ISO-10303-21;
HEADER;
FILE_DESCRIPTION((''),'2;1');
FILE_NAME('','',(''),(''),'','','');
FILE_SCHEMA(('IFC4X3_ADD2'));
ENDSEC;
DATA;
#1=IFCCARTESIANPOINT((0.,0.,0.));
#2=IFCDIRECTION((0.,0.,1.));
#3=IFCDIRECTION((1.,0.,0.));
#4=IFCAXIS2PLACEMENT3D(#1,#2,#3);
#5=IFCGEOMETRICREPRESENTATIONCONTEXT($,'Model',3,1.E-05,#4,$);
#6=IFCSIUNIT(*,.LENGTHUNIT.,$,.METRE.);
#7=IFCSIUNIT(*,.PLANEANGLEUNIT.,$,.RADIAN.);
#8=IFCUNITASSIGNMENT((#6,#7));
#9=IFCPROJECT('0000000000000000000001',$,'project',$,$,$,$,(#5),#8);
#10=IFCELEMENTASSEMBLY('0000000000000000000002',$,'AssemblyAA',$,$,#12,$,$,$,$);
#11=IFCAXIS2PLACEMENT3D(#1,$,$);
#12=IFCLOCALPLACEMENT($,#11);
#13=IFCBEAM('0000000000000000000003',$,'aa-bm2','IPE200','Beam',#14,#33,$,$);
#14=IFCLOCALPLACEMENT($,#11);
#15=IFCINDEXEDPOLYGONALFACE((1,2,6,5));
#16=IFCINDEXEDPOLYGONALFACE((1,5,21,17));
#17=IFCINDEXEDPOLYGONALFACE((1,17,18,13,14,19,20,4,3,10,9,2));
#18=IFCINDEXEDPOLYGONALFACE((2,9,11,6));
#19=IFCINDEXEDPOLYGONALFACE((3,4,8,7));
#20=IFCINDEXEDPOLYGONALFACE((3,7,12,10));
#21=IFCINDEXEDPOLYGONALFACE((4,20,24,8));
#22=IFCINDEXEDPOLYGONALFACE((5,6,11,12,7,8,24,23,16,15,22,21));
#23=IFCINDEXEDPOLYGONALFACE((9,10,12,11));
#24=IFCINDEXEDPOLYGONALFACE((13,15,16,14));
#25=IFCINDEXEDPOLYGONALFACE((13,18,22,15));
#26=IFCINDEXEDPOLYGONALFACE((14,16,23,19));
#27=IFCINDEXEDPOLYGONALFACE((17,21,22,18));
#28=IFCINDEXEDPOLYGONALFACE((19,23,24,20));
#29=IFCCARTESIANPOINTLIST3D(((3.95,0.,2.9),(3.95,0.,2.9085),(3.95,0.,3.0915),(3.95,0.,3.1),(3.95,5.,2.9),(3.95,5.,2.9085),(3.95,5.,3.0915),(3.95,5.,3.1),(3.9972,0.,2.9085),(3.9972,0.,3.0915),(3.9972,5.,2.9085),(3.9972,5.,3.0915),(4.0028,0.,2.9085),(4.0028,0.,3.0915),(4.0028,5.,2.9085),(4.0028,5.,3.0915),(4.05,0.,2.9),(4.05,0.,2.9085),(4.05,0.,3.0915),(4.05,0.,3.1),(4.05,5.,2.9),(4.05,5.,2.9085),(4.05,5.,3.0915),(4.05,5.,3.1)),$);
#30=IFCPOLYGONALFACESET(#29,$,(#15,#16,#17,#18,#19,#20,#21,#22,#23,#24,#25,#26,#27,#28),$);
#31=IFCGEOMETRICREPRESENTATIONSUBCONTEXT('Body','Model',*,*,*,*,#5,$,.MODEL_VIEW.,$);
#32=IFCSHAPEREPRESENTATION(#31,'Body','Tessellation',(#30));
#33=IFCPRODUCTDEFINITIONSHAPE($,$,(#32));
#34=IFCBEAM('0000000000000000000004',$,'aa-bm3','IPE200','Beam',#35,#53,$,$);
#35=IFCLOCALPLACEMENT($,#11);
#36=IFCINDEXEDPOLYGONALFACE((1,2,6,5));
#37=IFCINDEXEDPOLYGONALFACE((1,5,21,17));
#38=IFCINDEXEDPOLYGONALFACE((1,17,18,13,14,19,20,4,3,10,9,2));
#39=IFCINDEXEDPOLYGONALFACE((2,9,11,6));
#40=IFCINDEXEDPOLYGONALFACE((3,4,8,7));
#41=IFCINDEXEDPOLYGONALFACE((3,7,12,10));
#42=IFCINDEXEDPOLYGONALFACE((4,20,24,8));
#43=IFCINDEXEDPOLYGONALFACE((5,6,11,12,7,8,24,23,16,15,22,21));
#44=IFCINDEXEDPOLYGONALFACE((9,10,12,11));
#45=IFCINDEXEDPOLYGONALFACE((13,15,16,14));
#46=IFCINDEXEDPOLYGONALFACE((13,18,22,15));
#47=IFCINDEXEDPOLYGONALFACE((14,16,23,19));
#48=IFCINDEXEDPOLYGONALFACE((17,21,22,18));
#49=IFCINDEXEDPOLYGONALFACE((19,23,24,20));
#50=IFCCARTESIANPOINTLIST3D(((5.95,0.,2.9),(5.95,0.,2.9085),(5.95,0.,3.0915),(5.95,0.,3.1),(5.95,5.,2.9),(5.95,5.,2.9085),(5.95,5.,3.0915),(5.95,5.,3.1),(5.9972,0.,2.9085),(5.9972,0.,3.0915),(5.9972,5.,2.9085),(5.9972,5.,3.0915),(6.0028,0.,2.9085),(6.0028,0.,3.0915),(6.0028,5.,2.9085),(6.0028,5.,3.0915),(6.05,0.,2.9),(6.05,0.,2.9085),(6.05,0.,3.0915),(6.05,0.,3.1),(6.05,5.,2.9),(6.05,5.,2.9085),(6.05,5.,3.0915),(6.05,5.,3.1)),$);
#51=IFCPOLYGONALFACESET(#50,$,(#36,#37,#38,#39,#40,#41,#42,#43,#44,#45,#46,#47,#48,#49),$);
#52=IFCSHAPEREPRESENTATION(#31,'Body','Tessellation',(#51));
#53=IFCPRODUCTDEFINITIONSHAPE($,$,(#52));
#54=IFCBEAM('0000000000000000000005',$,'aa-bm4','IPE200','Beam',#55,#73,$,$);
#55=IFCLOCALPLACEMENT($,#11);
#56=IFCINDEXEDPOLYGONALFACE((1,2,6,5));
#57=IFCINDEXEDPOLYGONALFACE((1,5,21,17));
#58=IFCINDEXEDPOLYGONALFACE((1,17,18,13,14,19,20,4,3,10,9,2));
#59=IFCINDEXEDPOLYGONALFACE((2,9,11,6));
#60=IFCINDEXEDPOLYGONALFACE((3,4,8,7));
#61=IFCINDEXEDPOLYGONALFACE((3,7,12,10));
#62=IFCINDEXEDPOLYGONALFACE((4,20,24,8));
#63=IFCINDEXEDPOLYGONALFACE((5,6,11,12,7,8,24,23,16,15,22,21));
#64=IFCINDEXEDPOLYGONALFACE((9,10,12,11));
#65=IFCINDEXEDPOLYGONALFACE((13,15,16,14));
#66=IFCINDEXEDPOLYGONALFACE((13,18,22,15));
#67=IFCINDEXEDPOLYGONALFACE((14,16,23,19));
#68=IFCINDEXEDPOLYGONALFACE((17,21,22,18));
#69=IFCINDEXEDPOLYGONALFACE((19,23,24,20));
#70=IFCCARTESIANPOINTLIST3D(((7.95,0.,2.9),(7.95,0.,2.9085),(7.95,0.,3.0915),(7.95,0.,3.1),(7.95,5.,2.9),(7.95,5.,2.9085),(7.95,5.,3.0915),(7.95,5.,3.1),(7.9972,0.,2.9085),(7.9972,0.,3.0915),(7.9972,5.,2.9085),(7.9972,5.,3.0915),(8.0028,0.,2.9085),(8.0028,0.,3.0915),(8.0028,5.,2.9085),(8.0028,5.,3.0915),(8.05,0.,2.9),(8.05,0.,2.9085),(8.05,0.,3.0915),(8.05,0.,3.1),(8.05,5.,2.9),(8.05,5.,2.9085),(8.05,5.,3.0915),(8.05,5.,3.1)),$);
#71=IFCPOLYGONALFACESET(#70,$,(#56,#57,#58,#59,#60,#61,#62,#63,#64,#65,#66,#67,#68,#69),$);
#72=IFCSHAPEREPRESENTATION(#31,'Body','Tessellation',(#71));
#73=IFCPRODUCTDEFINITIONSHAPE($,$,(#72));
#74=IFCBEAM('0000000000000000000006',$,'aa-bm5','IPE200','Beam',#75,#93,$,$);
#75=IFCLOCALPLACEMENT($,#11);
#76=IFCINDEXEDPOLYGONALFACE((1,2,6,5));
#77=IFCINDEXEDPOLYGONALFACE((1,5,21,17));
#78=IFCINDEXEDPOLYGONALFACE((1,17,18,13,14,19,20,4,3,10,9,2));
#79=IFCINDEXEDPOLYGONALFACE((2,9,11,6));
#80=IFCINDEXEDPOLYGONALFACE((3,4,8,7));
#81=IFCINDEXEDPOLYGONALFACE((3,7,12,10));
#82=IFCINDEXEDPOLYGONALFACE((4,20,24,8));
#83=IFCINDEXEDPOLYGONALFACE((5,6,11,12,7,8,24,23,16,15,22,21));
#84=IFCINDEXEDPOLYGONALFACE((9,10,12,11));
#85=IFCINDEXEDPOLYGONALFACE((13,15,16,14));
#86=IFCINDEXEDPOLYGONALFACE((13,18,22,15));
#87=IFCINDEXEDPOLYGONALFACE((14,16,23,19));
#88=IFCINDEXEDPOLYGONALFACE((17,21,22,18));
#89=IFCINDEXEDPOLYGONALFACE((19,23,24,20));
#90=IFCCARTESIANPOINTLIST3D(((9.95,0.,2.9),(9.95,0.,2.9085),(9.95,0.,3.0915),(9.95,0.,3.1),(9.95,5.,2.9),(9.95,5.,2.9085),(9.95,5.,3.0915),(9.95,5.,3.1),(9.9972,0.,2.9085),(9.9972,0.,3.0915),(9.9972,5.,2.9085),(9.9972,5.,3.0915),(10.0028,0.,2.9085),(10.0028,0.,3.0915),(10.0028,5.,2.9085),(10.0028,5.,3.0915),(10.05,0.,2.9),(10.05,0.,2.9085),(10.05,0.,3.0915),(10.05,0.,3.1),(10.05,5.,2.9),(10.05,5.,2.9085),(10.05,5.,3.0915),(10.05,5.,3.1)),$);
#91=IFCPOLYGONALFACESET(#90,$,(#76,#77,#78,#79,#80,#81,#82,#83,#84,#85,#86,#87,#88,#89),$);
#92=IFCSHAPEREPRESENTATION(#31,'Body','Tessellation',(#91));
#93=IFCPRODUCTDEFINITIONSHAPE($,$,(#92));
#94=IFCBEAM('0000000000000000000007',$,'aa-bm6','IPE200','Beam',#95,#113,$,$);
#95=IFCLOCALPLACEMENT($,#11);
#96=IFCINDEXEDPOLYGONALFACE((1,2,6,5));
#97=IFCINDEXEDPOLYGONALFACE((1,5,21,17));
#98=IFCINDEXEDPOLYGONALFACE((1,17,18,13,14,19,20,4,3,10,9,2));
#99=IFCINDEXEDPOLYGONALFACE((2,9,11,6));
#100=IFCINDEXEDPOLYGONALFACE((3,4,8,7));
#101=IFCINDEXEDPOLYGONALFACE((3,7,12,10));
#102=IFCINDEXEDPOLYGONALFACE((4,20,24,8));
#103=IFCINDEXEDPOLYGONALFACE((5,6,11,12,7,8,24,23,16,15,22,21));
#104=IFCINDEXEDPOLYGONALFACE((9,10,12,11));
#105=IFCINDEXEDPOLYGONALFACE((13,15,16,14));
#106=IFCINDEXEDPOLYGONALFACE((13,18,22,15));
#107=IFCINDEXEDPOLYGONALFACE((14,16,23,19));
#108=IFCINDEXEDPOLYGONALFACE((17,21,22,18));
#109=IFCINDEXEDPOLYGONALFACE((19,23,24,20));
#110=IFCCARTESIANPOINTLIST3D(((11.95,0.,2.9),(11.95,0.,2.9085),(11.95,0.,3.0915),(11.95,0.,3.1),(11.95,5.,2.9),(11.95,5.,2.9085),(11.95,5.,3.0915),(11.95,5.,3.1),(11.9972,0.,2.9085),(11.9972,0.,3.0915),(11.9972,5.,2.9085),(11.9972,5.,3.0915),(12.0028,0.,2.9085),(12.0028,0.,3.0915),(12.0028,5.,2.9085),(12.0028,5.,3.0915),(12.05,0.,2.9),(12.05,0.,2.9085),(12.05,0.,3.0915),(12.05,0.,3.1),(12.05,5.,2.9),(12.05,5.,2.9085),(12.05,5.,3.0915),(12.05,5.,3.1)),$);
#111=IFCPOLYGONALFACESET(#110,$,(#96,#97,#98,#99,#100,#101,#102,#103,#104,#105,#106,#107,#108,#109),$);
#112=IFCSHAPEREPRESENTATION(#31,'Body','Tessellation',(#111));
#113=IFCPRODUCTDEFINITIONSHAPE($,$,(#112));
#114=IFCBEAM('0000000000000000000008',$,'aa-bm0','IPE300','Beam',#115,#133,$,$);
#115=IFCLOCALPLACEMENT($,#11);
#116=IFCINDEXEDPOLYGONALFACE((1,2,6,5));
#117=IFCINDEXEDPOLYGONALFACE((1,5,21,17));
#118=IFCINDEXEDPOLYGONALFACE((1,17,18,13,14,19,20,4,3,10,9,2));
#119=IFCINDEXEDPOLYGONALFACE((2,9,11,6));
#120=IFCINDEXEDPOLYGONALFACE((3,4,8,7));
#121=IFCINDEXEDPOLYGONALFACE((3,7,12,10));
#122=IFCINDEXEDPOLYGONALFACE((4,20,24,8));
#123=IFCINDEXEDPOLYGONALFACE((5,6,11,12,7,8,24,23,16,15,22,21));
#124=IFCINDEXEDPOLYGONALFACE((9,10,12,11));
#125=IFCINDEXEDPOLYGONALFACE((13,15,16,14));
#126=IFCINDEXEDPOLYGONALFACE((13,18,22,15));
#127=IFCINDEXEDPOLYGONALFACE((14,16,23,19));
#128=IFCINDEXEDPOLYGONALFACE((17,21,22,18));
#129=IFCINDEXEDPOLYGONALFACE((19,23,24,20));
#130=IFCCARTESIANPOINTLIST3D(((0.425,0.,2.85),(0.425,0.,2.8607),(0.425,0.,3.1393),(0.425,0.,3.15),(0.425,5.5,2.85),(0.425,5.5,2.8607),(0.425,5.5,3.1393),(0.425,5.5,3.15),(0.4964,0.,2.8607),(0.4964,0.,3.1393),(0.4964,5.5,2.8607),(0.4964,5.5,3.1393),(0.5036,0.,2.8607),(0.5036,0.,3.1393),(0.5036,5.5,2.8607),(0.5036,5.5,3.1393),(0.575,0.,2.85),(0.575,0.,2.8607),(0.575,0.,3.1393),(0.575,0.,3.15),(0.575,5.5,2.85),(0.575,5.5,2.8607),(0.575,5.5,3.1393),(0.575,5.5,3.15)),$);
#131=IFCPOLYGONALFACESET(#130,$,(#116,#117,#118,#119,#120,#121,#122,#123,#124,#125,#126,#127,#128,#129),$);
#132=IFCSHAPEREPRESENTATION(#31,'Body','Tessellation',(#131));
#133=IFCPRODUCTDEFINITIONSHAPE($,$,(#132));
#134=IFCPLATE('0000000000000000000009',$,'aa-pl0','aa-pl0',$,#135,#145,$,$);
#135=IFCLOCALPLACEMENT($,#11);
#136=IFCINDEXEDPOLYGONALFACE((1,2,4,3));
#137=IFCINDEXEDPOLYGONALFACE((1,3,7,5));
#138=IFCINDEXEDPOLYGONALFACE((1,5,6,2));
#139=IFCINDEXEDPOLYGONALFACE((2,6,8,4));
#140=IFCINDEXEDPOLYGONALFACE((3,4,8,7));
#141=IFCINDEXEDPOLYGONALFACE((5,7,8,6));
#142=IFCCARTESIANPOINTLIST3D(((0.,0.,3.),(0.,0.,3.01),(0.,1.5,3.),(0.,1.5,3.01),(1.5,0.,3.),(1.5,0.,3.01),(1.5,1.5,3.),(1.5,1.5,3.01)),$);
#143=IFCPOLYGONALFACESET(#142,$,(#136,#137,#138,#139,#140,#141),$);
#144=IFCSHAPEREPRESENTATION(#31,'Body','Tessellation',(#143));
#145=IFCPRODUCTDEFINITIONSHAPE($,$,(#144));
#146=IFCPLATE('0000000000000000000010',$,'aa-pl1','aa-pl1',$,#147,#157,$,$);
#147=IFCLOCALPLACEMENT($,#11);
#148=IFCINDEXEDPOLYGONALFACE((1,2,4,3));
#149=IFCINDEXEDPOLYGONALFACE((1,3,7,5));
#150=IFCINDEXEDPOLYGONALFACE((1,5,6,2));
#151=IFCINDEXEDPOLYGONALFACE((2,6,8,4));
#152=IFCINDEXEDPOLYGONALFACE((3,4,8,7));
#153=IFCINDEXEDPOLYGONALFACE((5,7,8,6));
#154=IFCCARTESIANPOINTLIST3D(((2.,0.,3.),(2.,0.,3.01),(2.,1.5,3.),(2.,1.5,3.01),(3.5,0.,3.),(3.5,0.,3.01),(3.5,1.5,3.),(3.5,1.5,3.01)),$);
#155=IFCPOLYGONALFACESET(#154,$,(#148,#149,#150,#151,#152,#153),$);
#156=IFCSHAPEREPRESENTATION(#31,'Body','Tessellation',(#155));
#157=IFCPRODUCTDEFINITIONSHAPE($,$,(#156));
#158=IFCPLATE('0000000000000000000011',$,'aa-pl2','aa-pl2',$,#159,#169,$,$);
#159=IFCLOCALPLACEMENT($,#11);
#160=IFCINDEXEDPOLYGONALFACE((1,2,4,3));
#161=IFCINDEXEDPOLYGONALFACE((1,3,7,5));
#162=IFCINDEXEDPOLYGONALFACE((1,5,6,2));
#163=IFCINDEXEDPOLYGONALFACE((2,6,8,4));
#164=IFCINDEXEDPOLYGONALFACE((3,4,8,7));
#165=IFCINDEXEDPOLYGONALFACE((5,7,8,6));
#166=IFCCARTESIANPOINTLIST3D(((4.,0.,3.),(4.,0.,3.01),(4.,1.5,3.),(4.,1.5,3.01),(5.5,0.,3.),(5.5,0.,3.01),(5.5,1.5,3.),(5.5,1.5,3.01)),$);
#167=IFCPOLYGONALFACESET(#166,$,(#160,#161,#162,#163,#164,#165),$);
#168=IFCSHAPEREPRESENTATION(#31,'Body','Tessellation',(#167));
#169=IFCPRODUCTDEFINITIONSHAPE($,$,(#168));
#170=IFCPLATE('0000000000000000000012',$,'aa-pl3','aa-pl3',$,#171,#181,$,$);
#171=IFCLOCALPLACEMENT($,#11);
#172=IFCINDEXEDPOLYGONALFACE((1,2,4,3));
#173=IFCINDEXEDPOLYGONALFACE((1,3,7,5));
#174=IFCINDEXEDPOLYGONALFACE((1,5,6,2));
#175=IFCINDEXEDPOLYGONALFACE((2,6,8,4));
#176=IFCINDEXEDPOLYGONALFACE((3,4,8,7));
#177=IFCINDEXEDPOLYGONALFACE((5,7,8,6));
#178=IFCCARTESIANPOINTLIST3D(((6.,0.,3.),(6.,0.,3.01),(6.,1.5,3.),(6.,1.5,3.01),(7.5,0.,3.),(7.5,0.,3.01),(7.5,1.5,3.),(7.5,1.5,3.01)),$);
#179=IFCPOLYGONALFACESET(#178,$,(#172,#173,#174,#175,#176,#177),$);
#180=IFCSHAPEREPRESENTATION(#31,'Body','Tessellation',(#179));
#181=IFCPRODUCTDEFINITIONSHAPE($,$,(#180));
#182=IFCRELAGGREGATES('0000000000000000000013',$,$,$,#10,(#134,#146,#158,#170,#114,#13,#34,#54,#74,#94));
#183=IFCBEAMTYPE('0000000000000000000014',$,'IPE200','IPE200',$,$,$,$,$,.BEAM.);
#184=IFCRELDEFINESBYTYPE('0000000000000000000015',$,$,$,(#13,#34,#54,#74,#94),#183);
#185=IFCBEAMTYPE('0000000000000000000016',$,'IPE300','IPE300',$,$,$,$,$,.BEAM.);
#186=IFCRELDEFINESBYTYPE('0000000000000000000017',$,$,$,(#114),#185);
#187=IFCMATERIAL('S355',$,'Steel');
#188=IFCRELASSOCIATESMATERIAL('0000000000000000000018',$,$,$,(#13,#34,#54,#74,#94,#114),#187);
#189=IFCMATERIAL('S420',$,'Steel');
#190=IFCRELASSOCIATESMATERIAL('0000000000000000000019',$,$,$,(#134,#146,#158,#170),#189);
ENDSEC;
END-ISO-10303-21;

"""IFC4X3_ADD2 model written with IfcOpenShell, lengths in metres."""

from ifc_helpers import new_model, si_unit, frame, origin_with_axes, place, context, subcontext, project, line, indexed_curve, i_section, outline, extrude, material, material_profile, profile_set, profile_usage, type_object, element, aggregate, save


model = new_model("IFC4X3_ADD2")

# Units and contexts
model_context = context("Model", 3, precision=1e-05, world=origin_with_axes())
body_context = subcontext(model_context, "Body", "Model", "MODEL_VIEW")
ifc_project = project(units=[si_unit("LENGTHUNIT", "METRE"), si_unit("PLANEANGLEUNIT", "RADIAN")], contexts=[model_context])

# Element assembly, beams, plates
placement_1 = place(None, origin_with_axes())
placement_2 = place(placement_1, origin_with_axes())
assembly_placement = place(placement_2, origin_with_axes())
assembly = element("IfcElementAssembly", 1, at=assembly_placement, Name="AssemblyAA")
ifc_material_1 = material(Name="S355", Category="Steel")
ifc_material_profile_1 = material_profile(ifc_material_1, i_section(OverallWidth=0.1, OverallDepth=0.2, WebThickness=0.0056, FlangeThickness=0.0085), Name="IPE200", Category="LoadBearing")
ifc_profile_set_1 = profile_set([ifc_material_profile_1], Name="IPE200")
ifc_profile_usage_1 = profile_usage(ifc_profile_set_1, cardinal=5)
beam_type_1 = type_object("IfcBeamType", Name="IPE200", Description="IPE200", PredefinedType="BEAM")
placement_3 = place(assembly_placement, origin_with_axes())
beam_1_placement = place(placement_3, origin_with_axes())
beam_1 = element("IfcBeam", 2, at=beam_1_placement, type_object=beam_type_1, material=ifc_profile_usage_1, Name="aa-bm2", Description="IPE200", ObjectType="Beam", context=body_context, shape_type="SolidModel", body=[
    extrude(i_section(OverallWidth=0.1, OverallDepth=0.2, WebThickness=0.0056, FlangeThickness=0.0085), frame((4.0, 0.0, 3.0), z_axis=(0.0, 1.0, 0.0), x_axis=(-1.0, 0.0, 0.0)), (0.0, 0.0, 1.0), 5.0),
])
ifc_material_profile_2 = material_profile(ifc_material_1, i_section(OverallWidth=0.1, OverallDepth=0.2, WebThickness=0.0056, FlangeThickness=0.0085), Name="IPE200", Category="LoadBearing")
ifc_profile_set_2 = profile_set([ifc_material_profile_2], Name="IPE200")
ifc_profile_usage_2 = profile_usage(ifc_profile_set_2, cardinal=5)
placement_4 = place(assembly_placement, origin_with_axes())
beam_2_placement = place(placement_4, origin_with_axes())
beam_2 = element("IfcBeam", 3, at=beam_2_placement, type_object=beam_type_1, material=ifc_profile_usage_2, Name="aa-bm3", Description="IPE200", ObjectType="Beam", context=body_context, shape_type="SolidModel", body=[
    extrude(i_section(OverallWidth=0.1, OverallDepth=0.2, WebThickness=0.0056, FlangeThickness=0.0085), frame((6.0, 0.0, 3.0), z_axis=(0.0, 1.0, 0.0), x_axis=(-1.0, 0.0, 0.0)), (0.0, 0.0, 1.0), 5.0),
])
ifc_material_profile_3 = material_profile(ifc_material_1, i_section(OverallWidth=0.1, OverallDepth=0.2, WebThickness=0.0056, FlangeThickness=0.0085), Name="IPE200", Category="LoadBearing")
ifc_profile_set_3 = profile_set([ifc_material_profile_3], Name="IPE200")
ifc_profile_usage_3 = profile_usage(ifc_profile_set_3, cardinal=5)
placement_5 = place(assembly_placement, origin_with_axes())
beam_3_placement = place(placement_5, origin_with_axes())
beam_3 = element("IfcBeam", 4, at=beam_3_placement, type_object=beam_type_1, material=ifc_profile_usage_3, Name="aa-bm4", Description="IPE200", ObjectType="Beam", context=body_context, shape_type="SolidModel", body=[
    extrude(i_section(OverallWidth=0.1, OverallDepth=0.2, WebThickness=0.0056, FlangeThickness=0.0085), frame((8.0, 0.0, 3.0), z_axis=(0.0, 1.0, 0.0), x_axis=(-1.0, 0.0, 0.0)), (0.0, 0.0, 1.0), 5.0),
])
ifc_material_profile_4 = material_profile(ifc_material_1, i_section(OverallWidth=0.1, OverallDepth=0.2, WebThickness=0.0056, FlangeThickness=0.0085), Name="IPE200", Category="LoadBearing")
ifc_profile_set_4 = profile_set([ifc_material_profile_4], Name="IPE200")
ifc_profile_usage_4 = profile_usage(ifc_profile_set_4, cardinal=5)
placement_6 = place(assembly_placement, origin_with_axes())
beam_4_placement = place(placement_6, origin_with_axes())
beam_4 = element("IfcBeam", 5, at=beam_4_placement, type_object=beam_type_1, material=ifc_profile_usage_4, Name="aa-bm5", Description="IPE200", ObjectType="Beam", context=body_context, shape_type="SolidModel", body=[
    extrude(i_section(OverallWidth=0.1, OverallDepth=0.2, WebThickness=0.0056, FlangeThickness=0.0085), frame((10.0, 0.0, 3.0), z_axis=(0.0, 1.0, 0.0), x_axis=(-1.0, 0.0, 0.0)), (0.0, 0.0, 1.0), 5.0),
])
ifc_material_profile_5 = material_profile(ifc_material_1, i_section(OverallWidth=0.1, OverallDepth=0.2, WebThickness=0.0056, FlangeThickness=0.0085), Name="IPE200", Category="LoadBearing")
ifc_profile_set_5 = profile_set([ifc_material_profile_5], Name="IPE200")
ifc_profile_usage_5 = profile_usage(ifc_profile_set_5, cardinal=5)
placement_7 = place(assembly_placement, origin_with_axes())
beam_5_placement = place(placement_7, origin_with_axes())
beam_5 = element("IfcBeam", 6, at=beam_5_placement, type_object=beam_type_1, material=ifc_profile_usage_5, Name="aa-bm6", Description="IPE200", ObjectType="Beam", context=body_context, shape_type="SolidModel", body=[
    extrude(i_section(OverallWidth=0.1, OverallDepth=0.2, WebThickness=0.0056, FlangeThickness=0.0085), frame((12.0, 0.0, 3.0), z_axis=(0.0, 1.0, 0.0), x_axis=(-1.0, 0.0, 0.0)), (0.0, 0.0, 1.0), 5.0),
])
ifc_material_profile_6 = material_profile(ifc_material_1, i_section(OverallWidth=0.15, OverallDepth=0.3, WebThickness=0.0071, FlangeThickness=0.0107), Name="IPE300", Category="LoadBearing")
ifc_profile_set_6 = profile_set([ifc_material_profile_6], Name="IPE300")
ifc_profile_usage_6 = profile_usage(ifc_profile_set_6, cardinal=5)
beam_type_2 = type_object("IfcBeamType", Name="IPE300", Description="IPE300", PredefinedType="BEAM")
placement_8 = place(assembly_placement, origin_with_axes())
beam_6_placement = place(placement_8, origin_with_axes())
beam_6 = element("IfcBeam", 7, at=beam_6_placement, type_object=beam_type_2, material=ifc_profile_usage_6, Name="aa-bm0", Description="IPE300", ObjectType="Beam", context=body_context, shape_type="SolidModel", body=[
    extrude(i_section(OverallWidth=0.15, OverallDepth=0.3, WebThickness=0.0071, FlangeThickness=0.0107), frame((0.5, 0.0, 3.0), z_axis=(0.0, 1.0, 0.0), x_axis=(-1.0, 0.0, 0.0)), (0.0, 0.0, 1.0), 5.5),
])
ifc_material_2 = material(Name="S420", Category="Steel")
plate_1_placement = place(None, origin_with_axes())
plate_1 = element("IfcPlate", 8, at=plate_1_placement, material=ifc_material_2, Name="aa-pl0", Description="aa-pl0", context=body_context, shape_type="SolidModel", body=[
    extrude(outline(indexed_curve([(0.0, 0.0), (0.0, 1.5), (1.5, 0.0), (1.5, 1.5)], segments=[line(3, 1), line(1, 2), line(2, 4), line(4, 3)])), frame((0.0, 0.0, 3.0), z_axis=(0.0, 0.0, 1.0), x_axis=(1.0, 0.0, 0.0)), (0.0, 0.0, 1.0), 0.01),
])
plate_2_placement = place(None, origin_with_axes())
plate_2 = element("IfcPlate", 9, at=plate_2_placement, material=ifc_material_2, Name="aa-pl1", Description="aa-pl1", context=body_context, shape_type="SolidModel", body=[
    extrude(outline(indexed_curve([(2.0, 0.0), (2.0, 1.5), (3.5, 0.0), (3.5, 1.5)], segments=[line(3, 1), line(1, 2), line(2, 4), line(4, 3)])), frame((0.0, 0.0, 3.0), z_axis=(0.0, 0.0, 1.0), x_axis=(1.0, 0.0, 0.0)), (0.0, 0.0, 1.0), 0.01),
])
plate_3_placement = place(None, origin_with_axes())
plate_3 = element("IfcPlate", 10, at=plate_3_placement, material=ifc_material_2, Name="aa-pl2", Description="aa-pl2", context=body_context, shape_type="SolidModel", body=[
    extrude(outline(indexed_curve([(4.0, 0.0), (4.0, 1.5), (5.5, 0.0), (5.5, 1.5)], segments=[line(3, 1), line(1, 2), line(2, 4), line(4, 3)])), frame((0.0, 0.0, 3.0), z_axis=(0.0, 0.0, 1.0), x_axis=(1.0, 0.0, 0.0)), (0.0, 0.0, 1.0), 0.01),
])
plate_4_placement = place(None, origin_with_axes())
plate_4 = element("IfcPlate", 11, at=plate_4_placement, material=ifc_material_2, Name="aa-pl3", Description="aa-pl3", context=body_context, shape_type="SolidModel", body=[
    extrude(outline(indexed_curve([(6.0, 0.0), (6.0, 1.5), (7.5, 0.0), (7.5, 1.5)], segments=[line(3, 1), line(1, 2), line(2, 4), line(4, 3)])), frame((0.0, 0.0, 3.0), z_axis=(0.0, 0.0, 1.0), x_axis=(1.0, 0.0, 0.0)), (0.0, 0.0, 1.0), 0.01),
])
aggregate(assembly, [plate_1, plate_2, plate_3, plate_4, beam_6, beam_1, beam_2, beam_3, beam_4, beam_5])

save(model, "model.ifc")
